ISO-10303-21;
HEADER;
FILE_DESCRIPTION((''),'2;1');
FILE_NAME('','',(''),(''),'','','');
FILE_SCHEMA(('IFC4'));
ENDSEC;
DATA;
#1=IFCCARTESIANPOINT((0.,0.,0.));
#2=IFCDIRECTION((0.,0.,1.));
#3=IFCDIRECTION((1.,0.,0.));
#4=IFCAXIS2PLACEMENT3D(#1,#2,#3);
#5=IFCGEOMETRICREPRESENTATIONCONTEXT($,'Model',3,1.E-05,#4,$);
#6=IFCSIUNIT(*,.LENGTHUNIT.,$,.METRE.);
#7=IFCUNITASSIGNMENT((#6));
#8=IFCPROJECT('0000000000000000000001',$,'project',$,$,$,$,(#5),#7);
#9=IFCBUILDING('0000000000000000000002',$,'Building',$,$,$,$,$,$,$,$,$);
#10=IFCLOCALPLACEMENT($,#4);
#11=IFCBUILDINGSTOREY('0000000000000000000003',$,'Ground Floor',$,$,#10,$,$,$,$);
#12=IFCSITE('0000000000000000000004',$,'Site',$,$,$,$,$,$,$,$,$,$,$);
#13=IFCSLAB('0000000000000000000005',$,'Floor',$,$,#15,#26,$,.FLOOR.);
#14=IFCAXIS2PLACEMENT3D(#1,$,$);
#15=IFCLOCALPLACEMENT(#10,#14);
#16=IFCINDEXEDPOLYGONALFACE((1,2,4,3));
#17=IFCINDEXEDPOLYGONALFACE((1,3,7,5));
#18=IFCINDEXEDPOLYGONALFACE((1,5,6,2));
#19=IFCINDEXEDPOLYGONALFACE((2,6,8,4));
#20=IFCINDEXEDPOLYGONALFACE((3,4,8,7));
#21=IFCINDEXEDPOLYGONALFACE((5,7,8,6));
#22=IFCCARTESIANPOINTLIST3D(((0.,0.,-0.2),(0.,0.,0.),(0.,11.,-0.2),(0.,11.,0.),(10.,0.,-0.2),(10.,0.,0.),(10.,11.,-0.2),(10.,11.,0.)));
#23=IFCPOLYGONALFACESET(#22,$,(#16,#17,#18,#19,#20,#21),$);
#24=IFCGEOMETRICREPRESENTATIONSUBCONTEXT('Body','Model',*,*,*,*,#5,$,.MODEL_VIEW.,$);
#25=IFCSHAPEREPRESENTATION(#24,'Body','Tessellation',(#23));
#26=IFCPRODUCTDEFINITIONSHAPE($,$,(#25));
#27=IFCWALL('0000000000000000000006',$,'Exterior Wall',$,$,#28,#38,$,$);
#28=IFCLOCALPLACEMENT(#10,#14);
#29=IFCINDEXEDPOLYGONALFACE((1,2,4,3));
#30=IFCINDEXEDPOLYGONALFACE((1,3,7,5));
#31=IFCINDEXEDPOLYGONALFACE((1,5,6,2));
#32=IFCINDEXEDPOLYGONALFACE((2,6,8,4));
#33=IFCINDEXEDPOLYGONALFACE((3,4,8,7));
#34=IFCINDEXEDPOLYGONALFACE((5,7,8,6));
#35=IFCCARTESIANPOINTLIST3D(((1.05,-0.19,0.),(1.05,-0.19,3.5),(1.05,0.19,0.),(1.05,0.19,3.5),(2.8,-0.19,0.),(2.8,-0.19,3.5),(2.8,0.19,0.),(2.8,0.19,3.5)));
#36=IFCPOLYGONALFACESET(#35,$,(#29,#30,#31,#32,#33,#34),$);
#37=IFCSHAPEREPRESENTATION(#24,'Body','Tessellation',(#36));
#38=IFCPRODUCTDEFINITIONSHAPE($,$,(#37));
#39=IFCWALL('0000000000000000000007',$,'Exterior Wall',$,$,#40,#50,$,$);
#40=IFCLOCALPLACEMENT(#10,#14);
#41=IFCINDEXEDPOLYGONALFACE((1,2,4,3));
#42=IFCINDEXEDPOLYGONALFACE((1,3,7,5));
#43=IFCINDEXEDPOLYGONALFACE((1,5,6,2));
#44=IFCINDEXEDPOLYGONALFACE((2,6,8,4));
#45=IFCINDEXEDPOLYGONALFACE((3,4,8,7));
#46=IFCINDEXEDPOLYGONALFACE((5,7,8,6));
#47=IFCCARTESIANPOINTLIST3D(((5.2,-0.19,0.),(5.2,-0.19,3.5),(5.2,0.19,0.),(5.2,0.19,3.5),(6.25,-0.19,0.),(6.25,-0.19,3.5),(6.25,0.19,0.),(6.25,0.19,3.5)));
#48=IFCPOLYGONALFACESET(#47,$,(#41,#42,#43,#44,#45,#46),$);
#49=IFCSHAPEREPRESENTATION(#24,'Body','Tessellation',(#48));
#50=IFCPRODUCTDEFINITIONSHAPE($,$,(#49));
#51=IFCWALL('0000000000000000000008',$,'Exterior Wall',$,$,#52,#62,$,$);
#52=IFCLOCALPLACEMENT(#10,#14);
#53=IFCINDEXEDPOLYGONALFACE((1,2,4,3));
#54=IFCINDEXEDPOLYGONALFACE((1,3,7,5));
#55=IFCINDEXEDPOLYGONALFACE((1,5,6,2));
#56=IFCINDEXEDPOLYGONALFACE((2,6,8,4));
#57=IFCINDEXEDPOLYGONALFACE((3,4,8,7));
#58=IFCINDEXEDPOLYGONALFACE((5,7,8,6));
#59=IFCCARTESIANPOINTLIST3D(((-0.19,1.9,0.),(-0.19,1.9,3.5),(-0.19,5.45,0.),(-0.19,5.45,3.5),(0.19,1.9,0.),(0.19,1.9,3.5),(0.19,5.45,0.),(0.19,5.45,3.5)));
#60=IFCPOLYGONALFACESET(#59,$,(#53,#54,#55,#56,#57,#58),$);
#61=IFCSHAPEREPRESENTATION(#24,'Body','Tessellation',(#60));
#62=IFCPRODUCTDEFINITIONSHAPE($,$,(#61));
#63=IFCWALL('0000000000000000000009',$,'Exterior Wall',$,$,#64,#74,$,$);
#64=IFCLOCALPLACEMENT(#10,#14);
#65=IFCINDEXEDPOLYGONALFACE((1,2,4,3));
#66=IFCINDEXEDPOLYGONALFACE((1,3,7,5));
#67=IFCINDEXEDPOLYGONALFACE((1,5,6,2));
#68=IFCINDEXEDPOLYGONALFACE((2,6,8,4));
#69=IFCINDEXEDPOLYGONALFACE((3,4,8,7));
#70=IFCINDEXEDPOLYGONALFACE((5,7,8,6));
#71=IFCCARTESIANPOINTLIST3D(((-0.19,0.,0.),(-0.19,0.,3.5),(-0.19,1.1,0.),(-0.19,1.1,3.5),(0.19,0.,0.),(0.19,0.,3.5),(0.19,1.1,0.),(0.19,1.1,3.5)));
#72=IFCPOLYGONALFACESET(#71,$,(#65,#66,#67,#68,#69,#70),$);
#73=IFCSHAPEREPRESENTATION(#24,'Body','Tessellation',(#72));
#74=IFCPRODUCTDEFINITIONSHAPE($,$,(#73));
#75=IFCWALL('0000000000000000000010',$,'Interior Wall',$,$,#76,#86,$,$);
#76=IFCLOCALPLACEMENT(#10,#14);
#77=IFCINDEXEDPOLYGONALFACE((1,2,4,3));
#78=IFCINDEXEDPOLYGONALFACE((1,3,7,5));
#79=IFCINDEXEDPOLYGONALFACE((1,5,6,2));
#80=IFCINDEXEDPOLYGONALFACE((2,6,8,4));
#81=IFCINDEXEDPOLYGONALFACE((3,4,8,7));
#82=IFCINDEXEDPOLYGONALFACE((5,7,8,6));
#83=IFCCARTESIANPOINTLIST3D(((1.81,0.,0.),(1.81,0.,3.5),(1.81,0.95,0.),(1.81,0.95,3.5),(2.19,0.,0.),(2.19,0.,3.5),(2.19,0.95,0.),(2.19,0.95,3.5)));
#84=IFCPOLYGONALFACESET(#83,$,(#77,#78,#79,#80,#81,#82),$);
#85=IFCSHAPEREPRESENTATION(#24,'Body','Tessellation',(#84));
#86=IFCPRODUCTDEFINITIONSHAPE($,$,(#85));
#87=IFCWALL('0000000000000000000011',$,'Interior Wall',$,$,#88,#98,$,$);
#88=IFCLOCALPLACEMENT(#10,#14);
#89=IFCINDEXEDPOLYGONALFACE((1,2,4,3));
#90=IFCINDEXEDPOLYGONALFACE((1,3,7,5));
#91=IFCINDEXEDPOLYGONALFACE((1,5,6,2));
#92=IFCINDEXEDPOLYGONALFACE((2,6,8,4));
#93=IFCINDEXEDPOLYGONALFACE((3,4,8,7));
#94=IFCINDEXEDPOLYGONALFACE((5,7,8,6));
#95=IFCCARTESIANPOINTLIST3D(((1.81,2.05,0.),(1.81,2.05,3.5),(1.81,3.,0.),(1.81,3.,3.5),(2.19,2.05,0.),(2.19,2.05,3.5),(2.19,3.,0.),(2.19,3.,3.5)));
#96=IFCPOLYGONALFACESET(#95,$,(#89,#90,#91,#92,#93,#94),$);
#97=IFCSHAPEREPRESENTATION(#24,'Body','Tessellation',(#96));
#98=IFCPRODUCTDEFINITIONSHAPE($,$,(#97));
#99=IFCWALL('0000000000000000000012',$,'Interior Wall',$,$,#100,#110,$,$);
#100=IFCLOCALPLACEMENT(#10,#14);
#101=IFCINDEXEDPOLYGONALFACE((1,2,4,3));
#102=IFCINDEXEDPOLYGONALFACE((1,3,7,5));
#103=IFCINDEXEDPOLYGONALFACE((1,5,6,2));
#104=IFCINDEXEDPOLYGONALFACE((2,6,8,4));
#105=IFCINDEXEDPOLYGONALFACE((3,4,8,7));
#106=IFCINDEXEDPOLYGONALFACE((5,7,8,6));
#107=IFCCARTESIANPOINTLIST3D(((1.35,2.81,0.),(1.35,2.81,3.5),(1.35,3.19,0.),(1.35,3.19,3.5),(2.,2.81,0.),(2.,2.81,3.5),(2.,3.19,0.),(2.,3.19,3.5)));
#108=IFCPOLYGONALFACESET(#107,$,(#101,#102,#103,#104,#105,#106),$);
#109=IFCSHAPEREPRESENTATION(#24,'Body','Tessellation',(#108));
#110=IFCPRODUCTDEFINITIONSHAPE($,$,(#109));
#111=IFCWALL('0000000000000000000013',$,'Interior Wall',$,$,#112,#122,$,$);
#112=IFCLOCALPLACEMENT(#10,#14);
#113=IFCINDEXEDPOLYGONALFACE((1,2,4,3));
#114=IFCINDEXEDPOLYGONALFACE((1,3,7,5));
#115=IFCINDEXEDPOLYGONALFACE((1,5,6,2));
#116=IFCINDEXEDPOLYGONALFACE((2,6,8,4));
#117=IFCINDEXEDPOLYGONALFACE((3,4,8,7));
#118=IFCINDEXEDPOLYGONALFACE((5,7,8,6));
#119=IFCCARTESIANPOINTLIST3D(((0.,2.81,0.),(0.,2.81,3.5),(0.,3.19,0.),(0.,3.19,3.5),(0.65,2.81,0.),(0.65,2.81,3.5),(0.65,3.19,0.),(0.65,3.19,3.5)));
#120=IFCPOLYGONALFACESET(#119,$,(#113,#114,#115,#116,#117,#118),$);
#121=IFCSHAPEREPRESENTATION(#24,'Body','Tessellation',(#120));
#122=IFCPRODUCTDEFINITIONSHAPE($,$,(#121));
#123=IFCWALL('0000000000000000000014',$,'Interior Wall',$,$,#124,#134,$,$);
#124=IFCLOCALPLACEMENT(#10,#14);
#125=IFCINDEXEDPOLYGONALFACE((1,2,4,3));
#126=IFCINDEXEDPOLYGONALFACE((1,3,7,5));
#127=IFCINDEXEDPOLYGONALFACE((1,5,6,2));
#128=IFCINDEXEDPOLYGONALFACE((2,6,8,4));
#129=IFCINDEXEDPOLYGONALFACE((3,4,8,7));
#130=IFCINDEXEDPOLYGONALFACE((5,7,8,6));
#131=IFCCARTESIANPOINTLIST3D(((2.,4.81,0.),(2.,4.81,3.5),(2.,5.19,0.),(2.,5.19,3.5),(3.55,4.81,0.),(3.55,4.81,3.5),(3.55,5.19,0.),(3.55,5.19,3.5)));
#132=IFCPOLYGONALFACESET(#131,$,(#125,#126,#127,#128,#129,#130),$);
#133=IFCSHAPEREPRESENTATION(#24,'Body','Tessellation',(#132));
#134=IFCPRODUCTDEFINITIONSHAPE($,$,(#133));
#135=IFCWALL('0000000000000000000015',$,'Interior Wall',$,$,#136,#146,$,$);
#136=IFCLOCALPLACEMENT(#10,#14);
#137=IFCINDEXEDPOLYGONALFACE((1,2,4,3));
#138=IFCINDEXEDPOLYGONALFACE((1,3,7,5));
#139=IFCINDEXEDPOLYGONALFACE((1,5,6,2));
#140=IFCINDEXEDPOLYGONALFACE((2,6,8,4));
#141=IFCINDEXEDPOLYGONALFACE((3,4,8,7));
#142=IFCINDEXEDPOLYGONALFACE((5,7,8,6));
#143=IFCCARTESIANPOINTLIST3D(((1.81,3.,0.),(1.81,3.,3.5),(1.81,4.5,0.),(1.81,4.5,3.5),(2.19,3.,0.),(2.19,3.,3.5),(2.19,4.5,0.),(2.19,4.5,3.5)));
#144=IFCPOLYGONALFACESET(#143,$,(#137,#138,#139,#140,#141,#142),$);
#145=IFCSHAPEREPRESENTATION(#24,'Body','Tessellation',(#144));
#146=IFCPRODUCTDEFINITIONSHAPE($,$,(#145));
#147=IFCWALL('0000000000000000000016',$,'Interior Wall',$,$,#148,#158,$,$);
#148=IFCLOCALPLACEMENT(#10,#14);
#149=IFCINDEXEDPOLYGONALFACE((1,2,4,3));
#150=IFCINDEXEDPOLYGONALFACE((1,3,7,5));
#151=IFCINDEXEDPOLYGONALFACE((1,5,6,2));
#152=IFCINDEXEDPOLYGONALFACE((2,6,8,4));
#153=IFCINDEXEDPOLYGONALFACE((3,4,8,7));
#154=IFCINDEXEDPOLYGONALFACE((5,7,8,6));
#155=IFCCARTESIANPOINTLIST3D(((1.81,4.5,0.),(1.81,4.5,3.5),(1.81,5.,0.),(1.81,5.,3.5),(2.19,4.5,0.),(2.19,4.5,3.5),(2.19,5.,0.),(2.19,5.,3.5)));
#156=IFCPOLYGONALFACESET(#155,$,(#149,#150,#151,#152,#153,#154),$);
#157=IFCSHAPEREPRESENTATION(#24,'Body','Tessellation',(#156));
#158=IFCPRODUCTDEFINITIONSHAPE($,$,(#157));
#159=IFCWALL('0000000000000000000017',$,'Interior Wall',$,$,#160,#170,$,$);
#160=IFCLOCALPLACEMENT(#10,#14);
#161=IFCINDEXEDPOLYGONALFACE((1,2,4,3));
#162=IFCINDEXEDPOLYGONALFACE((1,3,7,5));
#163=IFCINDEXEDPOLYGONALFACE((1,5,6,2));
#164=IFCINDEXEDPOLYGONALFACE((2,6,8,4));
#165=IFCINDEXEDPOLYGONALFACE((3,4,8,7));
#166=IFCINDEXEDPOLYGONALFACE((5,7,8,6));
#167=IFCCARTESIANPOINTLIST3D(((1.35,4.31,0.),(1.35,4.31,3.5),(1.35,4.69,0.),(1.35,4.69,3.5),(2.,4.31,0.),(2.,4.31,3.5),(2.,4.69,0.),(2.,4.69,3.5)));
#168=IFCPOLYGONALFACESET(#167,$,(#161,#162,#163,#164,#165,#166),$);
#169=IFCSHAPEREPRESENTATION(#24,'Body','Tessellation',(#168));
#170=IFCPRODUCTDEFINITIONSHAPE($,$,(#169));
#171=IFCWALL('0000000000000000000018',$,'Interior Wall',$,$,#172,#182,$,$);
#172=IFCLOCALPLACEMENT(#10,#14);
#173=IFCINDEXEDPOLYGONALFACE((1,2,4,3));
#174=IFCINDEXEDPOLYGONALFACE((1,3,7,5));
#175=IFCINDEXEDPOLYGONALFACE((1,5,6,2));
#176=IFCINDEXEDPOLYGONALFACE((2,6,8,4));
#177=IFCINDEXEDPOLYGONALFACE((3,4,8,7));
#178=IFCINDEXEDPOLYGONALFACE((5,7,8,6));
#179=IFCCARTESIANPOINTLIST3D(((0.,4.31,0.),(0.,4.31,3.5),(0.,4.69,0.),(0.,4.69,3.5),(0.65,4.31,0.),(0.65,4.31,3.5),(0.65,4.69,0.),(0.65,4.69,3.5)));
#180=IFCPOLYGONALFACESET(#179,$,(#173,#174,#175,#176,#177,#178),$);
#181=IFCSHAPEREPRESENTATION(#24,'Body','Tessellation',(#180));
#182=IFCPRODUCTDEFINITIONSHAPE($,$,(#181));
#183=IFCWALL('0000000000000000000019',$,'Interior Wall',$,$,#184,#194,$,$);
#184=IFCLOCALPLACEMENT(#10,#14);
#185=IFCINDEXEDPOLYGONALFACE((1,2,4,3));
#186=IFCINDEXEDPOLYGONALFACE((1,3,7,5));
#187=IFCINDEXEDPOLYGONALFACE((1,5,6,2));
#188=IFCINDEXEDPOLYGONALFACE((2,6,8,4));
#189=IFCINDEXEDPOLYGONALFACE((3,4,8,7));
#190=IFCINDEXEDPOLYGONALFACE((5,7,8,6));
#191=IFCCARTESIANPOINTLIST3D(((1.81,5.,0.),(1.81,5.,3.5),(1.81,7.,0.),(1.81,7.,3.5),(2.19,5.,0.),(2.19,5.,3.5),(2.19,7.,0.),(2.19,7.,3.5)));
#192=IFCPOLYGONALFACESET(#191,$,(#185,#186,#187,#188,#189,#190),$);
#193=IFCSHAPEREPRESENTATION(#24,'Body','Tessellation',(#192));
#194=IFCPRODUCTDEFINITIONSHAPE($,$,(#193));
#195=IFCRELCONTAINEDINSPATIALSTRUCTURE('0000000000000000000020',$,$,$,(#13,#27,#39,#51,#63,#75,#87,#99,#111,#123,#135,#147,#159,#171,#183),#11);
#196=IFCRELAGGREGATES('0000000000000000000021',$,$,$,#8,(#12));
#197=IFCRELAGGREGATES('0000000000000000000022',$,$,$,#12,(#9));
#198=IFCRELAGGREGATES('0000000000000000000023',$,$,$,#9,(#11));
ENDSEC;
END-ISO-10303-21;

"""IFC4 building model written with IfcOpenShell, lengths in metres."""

from ifc_helpers import new_model, si_unit, frame, origin_with_axes, place, context, subcontext, project, spatial, indexed_curve, outline, extrude, element, save


model = new_model("IFC4")

# Units and contexts
model_context = context("Model", 3, precision=1e-05, world=origin_with_axes())
body_context = subcontext(model_context, "Body", "Model", "MODEL_VIEW")
ifc_project = project(units=[si_unit("LENGTHUNIT", "METRE")], contexts=[model_context])

# Site, building, storey
site = spatial("IfcSite", under=ifc_project, Name="Site")
building = spatial("IfcBuilding", under=site, Name="Building")
storey_placement = place(None, origin_with_axes())
storey = spatial("IfcBuildingStorey", under=building, at=storey_placement, Name="Ground Floor")

# Slab
slab_placement = place(storey_placement, frame((0.0, 0.0, -0.2), z_axis=(0.0, 0.0, 1.0), x_axis=(1.0, 0.0, 0.0)))
element("IfcSlab", 1, at=slab_placement, inside=storey, Name="Floor", PredefinedType="FLOOR", context=body_context, shape_type="SweptSolid", body=[
    extrude(outline(indexed_curve([(0.0, 0.0), (10.0, 0.0), (10.0, 11.0), (0.0, 11.0)])), None, (0.0, 0.0, 1.0), 0.2),
])

# Walls
wall_1_placement = place(storey_placement, frame((1.05, 0.0, 0.0), z_axis=(0.0, 0.0, 1.0), x_axis=(1.0, 0.0, 0.0)))
element("IfcWall", 2, at=wall_1_placement, inside=storey, Name="Exterior Wall", context=body_context, shape_type="SweptSolid", body=[
    extrude(outline(indexed_curve([(0.0, 0.0), (0.0, 0.38), (1.75, 0.38), (1.75, 0.0), (0.0, 0.0)], self_intersect=False)), frame((0.0, -0.19, 0.0), z_axis=(0.0, 0.0, 1.0), x_axis=(1.0, 0.0, 0.0)), (0.0, 0.0, 1.0), 3.5),
])
wall_2_placement = place(storey_placement, frame((5.2, 0.0, 0.0), z_axis=(0.0, 0.0, 1.0), x_axis=(1.0, 0.0, 0.0)))
element("IfcWall", 3, at=wall_2_placement, inside=storey, Name="Exterior Wall", context=body_context, shape_type="SweptSolid", body=[
    extrude(outline(indexed_curve([(0.0, 0.0), (0.0, 0.38), (1.05, 0.38), (1.05, 0.0), (0.0, 0.0)], self_intersect=False)), frame((0.0, -0.19, 0.0), z_axis=(0.0, 0.0, 1.0), x_axis=(1.0, 0.0, 0.0)), (0.0, 0.0, 1.0), 3.5),
])
wall_3_placement = place(storey_placement, frame((0.0, 5.45, 0.0), z_axis=(0.0, 0.0, 1.0), x_axis=(0.0, -1.0, 0.0)))
element("IfcWall", 4, at=wall_3_placement, inside=storey, Name="Exterior Wall", context=body_context, shape_type="SweptSolid", body=[
    extrude(outline(indexed_curve([(0.0, 0.0), (0.0, 0.38), (3.55, 0.38), (3.55, 0.0), (0.0, 0.0)], self_intersect=False)), frame((0.0, -0.19, 0.0), z_axis=(0.0, 0.0, 1.0), x_axis=(1.0, 0.0, 0.0)), (0.0, 0.0, 1.0), 3.5),
])
wall_4_placement = place(storey_placement, frame((0.0, 1.1, 0.0), z_axis=(0.0, 0.0, 1.0), x_axis=(0.0, -1.0, 0.0)))
element("IfcWall", 5, at=wall_4_placement, inside=storey, Name="Exterior Wall", context=body_context, shape_type="SweptSolid", body=[
    extrude(outline(indexed_curve([(0.0, 0.0), (0.0, 0.38), (1.1, 0.38), (1.1, 0.0), (0.0, 0.0)], self_intersect=False)), frame((0.0, -0.19, 0.0), z_axis=(0.0, 0.0, 1.0), x_axis=(1.0, 0.0, 0.0)), (0.0, 0.0, 1.0), 3.5),
])
wall_5_placement = place(storey_placement, frame((2.0, 0.0, 0.0), z_axis=(0.0, 0.0, 1.0), x_axis=(0.0, 1.0, 0.0)))
element("IfcWall", 6, at=wall_5_placement, inside=storey, Name="Interior Wall", context=body_context, shape_type="SweptSolid", body=[
    extrude(outline(indexed_curve([(0.0, 0.0), (0.0, 0.38), (0.95, 0.38), (0.95, 0.0), (0.0, 0.0)], self_intersect=False)), frame((0.0, -0.19, 0.0), z_axis=(0.0, 0.0, 1.0), x_axis=(1.0, 0.0, 0.0)), (0.0, 0.0, 1.0), 3.5),
])
wall_6_placement = place(storey_placement, frame((2.0, 2.05, 0.0), z_axis=(0.0, 0.0, 1.0), x_axis=(0.0, 1.0, 0.0)))
element("IfcWall", 7, at=wall_6_placement, inside=storey, Name="Interior Wall", context=body_context, shape_type="SweptSolid", body=[
    extrude(outline(indexed_curve([(0.0, 0.0), (0.0, 0.38), (0.95, 0.38), (0.95, 0.0), (0.0, 0.0)], self_intersect=False)), frame((0.0, -0.19, 0.0), z_axis=(0.0, 0.0, 1.0), x_axis=(1.0, 0.0, 0.0)), (0.0, 0.0, 1.0), 3.5),
])
for number, where, z_axis, x_axis, name in (
    (8, (2.0, 3.0, 0.0), (0.0, 0.0, 1.0), (-1.0, 0.0, 0.0), "Interior Wall"),
    (9, (0.65, 3.0, 0.0), (0.0, 0.0, 1.0), (-1.0, 0.0, 0.0), "Interior Wall"),
):
    element("IfcWall", number, at=place(storey_placement, frame(where, z_axis=z_axis, x_axis=x_axis)), inside=storey, Name=name, context=body_context, shape_type="SweptSolid", body=[
        extrude(outline(indexed_curve([(0.0, 0.0), (0.0, 0.38), (0.65, 0.38), (0.65, 0.0), (0.0, 0.0)], self_intersect=False)), frame((0.0, -0.19, 0.0), z_axis=(0.0, 0.0, 1.0), x_axis=(1.0, 0.0, 0.0)), (0.0, 0.0, 1.0), 3.5),
    ])
wall_7_placement = place(storey_placement, frame((3.55, 5.0, 0.0), z_axis=(0.0, 0.0, 1.0), x_axis=(-1.0, 0.0, 0.0)))
element("IfcWall", 10, at=wall_7_placement, inside=storey, Name="Interior Wall", context=body_context, shape_type="SweptSolid", body=[
    extrude(outline(indexed_curve([(0.0, 0.0), (0.0, 0.38), (1.55, 0.38), (1.55, 0.0), (0.0, 0.0)], self_intersect=False)), frame((0.0, -0.19, 0.0), z_axis=(0.0, 0.0, 1.0), x_axis=(1.0, 0.0, 0.0)), (0.0, 0.0, 1.0), 3.5),
])
wall_8_placement = place(storey_placement, frame((2.0, 4.5, 0.0), z_axis=(0.0, 0.0, 1.0), x_axis=(0.0, -1.0, 0.0)))
element("IfcWall", 11, at=wall_8_placement, inside=storey, Name="Interior Wall", context=body_context, shape_type="SweptSolid", body=[
    extrude(outline(indexed_curve([(0.0, 0.0), (0.0, 0.38), (1.5, 0.38), (1.5, 0.0), (0.0, 0.0)], self_intersect=False)), frame((0.0, -0.19, 0.0), z_axis=(0.0, 0.0, 1.0), x_axis=(1.0, 0.0, 0.0)), (0.0, 0.0, 1.0), 3.5),
])
wall_9_placement = place(storey_placement, frame((2.0, 5.0, 0.0), z_axis=(0.0, 0.0, 1.0), x_axis=(0.0, -1.0, 0.0)))
element("IfcWall", 12, at=wall_9_placement, inside=storey, Name="Interior Wall", context=body_context, shape_type="SweptSolid", body=[
    extrude(outline(indexed_curve([(0.0, 0.0), (0.0, 0.38), (0.5, 0.38), (0.5, 0.0), (0.0, 0.0)], self_intersect=False)), frame((0.0, -0.19, 0.0), z_axis=(0.0, 0.0, 1.0), x_axis=(1.0, 0.0, 0.0)), (0.0, 0.0, 1.0), 3.5),
])
for number, where, z_axis, x_axis, name in (
    (13, (2.0, 4.5, 0.0), (0.0, 0.0, 1.0), (-1.0, 0.0, 0.0), "Interior Wall"),
    (14, (0.65, 4.5, 0.0), (0.0, 0.0, 1.0), (-1.0, 0.0, 0.0), "Interior Wall"),
):
    element("IfcWall", number, at=place(storey_placement, frame(where, z_axis=z_axis, x_axis=x_axis)), inside=storey, Name=name, context=body_context, shape_type="SweptSolid", body=[
        extrude(outline(indexed_curve([(0.0, 0.0), (0.0, 0.38), (0.65, 0.38), (0.65, 0.0), (0.0, 0.0)], self_intersect=False)), frame((0.0, -0.19, 0.0), z_axis=(0.0, 0.0, 1.0), x_axis=(1.0, 0.0, 0.0)), (0.0, 0.0, 1.0), 3.5),
    ])
wall_10_placement = place(storey_placement, frame((2.0, 5.0, 0.0), z_axis=(0.0, 0.0, 1.0), x_axis=(0.0, 1.0, 0.0)))
element("IfcWall", 15, at=wall_10_placement, inside=storey, Name="Interior Wall", context=body_context, shape_type="SweptSolid", body=[
    extrude(outline(indexed_curve([(0.0, 0.0), (0.0, 0.38), (2.0, 0.38), (2.0, 0.0), (0.0, 0.0)], self_intersect=False)), frame((0.0, -0.19, 0.0), z_axis=(0.0, 0.0, 1.0), x_axis=(1.0, 0.0, 0.0)), (0.0, 0.0, 1.0), 3.5),
])

save(model, "model.ifc")
